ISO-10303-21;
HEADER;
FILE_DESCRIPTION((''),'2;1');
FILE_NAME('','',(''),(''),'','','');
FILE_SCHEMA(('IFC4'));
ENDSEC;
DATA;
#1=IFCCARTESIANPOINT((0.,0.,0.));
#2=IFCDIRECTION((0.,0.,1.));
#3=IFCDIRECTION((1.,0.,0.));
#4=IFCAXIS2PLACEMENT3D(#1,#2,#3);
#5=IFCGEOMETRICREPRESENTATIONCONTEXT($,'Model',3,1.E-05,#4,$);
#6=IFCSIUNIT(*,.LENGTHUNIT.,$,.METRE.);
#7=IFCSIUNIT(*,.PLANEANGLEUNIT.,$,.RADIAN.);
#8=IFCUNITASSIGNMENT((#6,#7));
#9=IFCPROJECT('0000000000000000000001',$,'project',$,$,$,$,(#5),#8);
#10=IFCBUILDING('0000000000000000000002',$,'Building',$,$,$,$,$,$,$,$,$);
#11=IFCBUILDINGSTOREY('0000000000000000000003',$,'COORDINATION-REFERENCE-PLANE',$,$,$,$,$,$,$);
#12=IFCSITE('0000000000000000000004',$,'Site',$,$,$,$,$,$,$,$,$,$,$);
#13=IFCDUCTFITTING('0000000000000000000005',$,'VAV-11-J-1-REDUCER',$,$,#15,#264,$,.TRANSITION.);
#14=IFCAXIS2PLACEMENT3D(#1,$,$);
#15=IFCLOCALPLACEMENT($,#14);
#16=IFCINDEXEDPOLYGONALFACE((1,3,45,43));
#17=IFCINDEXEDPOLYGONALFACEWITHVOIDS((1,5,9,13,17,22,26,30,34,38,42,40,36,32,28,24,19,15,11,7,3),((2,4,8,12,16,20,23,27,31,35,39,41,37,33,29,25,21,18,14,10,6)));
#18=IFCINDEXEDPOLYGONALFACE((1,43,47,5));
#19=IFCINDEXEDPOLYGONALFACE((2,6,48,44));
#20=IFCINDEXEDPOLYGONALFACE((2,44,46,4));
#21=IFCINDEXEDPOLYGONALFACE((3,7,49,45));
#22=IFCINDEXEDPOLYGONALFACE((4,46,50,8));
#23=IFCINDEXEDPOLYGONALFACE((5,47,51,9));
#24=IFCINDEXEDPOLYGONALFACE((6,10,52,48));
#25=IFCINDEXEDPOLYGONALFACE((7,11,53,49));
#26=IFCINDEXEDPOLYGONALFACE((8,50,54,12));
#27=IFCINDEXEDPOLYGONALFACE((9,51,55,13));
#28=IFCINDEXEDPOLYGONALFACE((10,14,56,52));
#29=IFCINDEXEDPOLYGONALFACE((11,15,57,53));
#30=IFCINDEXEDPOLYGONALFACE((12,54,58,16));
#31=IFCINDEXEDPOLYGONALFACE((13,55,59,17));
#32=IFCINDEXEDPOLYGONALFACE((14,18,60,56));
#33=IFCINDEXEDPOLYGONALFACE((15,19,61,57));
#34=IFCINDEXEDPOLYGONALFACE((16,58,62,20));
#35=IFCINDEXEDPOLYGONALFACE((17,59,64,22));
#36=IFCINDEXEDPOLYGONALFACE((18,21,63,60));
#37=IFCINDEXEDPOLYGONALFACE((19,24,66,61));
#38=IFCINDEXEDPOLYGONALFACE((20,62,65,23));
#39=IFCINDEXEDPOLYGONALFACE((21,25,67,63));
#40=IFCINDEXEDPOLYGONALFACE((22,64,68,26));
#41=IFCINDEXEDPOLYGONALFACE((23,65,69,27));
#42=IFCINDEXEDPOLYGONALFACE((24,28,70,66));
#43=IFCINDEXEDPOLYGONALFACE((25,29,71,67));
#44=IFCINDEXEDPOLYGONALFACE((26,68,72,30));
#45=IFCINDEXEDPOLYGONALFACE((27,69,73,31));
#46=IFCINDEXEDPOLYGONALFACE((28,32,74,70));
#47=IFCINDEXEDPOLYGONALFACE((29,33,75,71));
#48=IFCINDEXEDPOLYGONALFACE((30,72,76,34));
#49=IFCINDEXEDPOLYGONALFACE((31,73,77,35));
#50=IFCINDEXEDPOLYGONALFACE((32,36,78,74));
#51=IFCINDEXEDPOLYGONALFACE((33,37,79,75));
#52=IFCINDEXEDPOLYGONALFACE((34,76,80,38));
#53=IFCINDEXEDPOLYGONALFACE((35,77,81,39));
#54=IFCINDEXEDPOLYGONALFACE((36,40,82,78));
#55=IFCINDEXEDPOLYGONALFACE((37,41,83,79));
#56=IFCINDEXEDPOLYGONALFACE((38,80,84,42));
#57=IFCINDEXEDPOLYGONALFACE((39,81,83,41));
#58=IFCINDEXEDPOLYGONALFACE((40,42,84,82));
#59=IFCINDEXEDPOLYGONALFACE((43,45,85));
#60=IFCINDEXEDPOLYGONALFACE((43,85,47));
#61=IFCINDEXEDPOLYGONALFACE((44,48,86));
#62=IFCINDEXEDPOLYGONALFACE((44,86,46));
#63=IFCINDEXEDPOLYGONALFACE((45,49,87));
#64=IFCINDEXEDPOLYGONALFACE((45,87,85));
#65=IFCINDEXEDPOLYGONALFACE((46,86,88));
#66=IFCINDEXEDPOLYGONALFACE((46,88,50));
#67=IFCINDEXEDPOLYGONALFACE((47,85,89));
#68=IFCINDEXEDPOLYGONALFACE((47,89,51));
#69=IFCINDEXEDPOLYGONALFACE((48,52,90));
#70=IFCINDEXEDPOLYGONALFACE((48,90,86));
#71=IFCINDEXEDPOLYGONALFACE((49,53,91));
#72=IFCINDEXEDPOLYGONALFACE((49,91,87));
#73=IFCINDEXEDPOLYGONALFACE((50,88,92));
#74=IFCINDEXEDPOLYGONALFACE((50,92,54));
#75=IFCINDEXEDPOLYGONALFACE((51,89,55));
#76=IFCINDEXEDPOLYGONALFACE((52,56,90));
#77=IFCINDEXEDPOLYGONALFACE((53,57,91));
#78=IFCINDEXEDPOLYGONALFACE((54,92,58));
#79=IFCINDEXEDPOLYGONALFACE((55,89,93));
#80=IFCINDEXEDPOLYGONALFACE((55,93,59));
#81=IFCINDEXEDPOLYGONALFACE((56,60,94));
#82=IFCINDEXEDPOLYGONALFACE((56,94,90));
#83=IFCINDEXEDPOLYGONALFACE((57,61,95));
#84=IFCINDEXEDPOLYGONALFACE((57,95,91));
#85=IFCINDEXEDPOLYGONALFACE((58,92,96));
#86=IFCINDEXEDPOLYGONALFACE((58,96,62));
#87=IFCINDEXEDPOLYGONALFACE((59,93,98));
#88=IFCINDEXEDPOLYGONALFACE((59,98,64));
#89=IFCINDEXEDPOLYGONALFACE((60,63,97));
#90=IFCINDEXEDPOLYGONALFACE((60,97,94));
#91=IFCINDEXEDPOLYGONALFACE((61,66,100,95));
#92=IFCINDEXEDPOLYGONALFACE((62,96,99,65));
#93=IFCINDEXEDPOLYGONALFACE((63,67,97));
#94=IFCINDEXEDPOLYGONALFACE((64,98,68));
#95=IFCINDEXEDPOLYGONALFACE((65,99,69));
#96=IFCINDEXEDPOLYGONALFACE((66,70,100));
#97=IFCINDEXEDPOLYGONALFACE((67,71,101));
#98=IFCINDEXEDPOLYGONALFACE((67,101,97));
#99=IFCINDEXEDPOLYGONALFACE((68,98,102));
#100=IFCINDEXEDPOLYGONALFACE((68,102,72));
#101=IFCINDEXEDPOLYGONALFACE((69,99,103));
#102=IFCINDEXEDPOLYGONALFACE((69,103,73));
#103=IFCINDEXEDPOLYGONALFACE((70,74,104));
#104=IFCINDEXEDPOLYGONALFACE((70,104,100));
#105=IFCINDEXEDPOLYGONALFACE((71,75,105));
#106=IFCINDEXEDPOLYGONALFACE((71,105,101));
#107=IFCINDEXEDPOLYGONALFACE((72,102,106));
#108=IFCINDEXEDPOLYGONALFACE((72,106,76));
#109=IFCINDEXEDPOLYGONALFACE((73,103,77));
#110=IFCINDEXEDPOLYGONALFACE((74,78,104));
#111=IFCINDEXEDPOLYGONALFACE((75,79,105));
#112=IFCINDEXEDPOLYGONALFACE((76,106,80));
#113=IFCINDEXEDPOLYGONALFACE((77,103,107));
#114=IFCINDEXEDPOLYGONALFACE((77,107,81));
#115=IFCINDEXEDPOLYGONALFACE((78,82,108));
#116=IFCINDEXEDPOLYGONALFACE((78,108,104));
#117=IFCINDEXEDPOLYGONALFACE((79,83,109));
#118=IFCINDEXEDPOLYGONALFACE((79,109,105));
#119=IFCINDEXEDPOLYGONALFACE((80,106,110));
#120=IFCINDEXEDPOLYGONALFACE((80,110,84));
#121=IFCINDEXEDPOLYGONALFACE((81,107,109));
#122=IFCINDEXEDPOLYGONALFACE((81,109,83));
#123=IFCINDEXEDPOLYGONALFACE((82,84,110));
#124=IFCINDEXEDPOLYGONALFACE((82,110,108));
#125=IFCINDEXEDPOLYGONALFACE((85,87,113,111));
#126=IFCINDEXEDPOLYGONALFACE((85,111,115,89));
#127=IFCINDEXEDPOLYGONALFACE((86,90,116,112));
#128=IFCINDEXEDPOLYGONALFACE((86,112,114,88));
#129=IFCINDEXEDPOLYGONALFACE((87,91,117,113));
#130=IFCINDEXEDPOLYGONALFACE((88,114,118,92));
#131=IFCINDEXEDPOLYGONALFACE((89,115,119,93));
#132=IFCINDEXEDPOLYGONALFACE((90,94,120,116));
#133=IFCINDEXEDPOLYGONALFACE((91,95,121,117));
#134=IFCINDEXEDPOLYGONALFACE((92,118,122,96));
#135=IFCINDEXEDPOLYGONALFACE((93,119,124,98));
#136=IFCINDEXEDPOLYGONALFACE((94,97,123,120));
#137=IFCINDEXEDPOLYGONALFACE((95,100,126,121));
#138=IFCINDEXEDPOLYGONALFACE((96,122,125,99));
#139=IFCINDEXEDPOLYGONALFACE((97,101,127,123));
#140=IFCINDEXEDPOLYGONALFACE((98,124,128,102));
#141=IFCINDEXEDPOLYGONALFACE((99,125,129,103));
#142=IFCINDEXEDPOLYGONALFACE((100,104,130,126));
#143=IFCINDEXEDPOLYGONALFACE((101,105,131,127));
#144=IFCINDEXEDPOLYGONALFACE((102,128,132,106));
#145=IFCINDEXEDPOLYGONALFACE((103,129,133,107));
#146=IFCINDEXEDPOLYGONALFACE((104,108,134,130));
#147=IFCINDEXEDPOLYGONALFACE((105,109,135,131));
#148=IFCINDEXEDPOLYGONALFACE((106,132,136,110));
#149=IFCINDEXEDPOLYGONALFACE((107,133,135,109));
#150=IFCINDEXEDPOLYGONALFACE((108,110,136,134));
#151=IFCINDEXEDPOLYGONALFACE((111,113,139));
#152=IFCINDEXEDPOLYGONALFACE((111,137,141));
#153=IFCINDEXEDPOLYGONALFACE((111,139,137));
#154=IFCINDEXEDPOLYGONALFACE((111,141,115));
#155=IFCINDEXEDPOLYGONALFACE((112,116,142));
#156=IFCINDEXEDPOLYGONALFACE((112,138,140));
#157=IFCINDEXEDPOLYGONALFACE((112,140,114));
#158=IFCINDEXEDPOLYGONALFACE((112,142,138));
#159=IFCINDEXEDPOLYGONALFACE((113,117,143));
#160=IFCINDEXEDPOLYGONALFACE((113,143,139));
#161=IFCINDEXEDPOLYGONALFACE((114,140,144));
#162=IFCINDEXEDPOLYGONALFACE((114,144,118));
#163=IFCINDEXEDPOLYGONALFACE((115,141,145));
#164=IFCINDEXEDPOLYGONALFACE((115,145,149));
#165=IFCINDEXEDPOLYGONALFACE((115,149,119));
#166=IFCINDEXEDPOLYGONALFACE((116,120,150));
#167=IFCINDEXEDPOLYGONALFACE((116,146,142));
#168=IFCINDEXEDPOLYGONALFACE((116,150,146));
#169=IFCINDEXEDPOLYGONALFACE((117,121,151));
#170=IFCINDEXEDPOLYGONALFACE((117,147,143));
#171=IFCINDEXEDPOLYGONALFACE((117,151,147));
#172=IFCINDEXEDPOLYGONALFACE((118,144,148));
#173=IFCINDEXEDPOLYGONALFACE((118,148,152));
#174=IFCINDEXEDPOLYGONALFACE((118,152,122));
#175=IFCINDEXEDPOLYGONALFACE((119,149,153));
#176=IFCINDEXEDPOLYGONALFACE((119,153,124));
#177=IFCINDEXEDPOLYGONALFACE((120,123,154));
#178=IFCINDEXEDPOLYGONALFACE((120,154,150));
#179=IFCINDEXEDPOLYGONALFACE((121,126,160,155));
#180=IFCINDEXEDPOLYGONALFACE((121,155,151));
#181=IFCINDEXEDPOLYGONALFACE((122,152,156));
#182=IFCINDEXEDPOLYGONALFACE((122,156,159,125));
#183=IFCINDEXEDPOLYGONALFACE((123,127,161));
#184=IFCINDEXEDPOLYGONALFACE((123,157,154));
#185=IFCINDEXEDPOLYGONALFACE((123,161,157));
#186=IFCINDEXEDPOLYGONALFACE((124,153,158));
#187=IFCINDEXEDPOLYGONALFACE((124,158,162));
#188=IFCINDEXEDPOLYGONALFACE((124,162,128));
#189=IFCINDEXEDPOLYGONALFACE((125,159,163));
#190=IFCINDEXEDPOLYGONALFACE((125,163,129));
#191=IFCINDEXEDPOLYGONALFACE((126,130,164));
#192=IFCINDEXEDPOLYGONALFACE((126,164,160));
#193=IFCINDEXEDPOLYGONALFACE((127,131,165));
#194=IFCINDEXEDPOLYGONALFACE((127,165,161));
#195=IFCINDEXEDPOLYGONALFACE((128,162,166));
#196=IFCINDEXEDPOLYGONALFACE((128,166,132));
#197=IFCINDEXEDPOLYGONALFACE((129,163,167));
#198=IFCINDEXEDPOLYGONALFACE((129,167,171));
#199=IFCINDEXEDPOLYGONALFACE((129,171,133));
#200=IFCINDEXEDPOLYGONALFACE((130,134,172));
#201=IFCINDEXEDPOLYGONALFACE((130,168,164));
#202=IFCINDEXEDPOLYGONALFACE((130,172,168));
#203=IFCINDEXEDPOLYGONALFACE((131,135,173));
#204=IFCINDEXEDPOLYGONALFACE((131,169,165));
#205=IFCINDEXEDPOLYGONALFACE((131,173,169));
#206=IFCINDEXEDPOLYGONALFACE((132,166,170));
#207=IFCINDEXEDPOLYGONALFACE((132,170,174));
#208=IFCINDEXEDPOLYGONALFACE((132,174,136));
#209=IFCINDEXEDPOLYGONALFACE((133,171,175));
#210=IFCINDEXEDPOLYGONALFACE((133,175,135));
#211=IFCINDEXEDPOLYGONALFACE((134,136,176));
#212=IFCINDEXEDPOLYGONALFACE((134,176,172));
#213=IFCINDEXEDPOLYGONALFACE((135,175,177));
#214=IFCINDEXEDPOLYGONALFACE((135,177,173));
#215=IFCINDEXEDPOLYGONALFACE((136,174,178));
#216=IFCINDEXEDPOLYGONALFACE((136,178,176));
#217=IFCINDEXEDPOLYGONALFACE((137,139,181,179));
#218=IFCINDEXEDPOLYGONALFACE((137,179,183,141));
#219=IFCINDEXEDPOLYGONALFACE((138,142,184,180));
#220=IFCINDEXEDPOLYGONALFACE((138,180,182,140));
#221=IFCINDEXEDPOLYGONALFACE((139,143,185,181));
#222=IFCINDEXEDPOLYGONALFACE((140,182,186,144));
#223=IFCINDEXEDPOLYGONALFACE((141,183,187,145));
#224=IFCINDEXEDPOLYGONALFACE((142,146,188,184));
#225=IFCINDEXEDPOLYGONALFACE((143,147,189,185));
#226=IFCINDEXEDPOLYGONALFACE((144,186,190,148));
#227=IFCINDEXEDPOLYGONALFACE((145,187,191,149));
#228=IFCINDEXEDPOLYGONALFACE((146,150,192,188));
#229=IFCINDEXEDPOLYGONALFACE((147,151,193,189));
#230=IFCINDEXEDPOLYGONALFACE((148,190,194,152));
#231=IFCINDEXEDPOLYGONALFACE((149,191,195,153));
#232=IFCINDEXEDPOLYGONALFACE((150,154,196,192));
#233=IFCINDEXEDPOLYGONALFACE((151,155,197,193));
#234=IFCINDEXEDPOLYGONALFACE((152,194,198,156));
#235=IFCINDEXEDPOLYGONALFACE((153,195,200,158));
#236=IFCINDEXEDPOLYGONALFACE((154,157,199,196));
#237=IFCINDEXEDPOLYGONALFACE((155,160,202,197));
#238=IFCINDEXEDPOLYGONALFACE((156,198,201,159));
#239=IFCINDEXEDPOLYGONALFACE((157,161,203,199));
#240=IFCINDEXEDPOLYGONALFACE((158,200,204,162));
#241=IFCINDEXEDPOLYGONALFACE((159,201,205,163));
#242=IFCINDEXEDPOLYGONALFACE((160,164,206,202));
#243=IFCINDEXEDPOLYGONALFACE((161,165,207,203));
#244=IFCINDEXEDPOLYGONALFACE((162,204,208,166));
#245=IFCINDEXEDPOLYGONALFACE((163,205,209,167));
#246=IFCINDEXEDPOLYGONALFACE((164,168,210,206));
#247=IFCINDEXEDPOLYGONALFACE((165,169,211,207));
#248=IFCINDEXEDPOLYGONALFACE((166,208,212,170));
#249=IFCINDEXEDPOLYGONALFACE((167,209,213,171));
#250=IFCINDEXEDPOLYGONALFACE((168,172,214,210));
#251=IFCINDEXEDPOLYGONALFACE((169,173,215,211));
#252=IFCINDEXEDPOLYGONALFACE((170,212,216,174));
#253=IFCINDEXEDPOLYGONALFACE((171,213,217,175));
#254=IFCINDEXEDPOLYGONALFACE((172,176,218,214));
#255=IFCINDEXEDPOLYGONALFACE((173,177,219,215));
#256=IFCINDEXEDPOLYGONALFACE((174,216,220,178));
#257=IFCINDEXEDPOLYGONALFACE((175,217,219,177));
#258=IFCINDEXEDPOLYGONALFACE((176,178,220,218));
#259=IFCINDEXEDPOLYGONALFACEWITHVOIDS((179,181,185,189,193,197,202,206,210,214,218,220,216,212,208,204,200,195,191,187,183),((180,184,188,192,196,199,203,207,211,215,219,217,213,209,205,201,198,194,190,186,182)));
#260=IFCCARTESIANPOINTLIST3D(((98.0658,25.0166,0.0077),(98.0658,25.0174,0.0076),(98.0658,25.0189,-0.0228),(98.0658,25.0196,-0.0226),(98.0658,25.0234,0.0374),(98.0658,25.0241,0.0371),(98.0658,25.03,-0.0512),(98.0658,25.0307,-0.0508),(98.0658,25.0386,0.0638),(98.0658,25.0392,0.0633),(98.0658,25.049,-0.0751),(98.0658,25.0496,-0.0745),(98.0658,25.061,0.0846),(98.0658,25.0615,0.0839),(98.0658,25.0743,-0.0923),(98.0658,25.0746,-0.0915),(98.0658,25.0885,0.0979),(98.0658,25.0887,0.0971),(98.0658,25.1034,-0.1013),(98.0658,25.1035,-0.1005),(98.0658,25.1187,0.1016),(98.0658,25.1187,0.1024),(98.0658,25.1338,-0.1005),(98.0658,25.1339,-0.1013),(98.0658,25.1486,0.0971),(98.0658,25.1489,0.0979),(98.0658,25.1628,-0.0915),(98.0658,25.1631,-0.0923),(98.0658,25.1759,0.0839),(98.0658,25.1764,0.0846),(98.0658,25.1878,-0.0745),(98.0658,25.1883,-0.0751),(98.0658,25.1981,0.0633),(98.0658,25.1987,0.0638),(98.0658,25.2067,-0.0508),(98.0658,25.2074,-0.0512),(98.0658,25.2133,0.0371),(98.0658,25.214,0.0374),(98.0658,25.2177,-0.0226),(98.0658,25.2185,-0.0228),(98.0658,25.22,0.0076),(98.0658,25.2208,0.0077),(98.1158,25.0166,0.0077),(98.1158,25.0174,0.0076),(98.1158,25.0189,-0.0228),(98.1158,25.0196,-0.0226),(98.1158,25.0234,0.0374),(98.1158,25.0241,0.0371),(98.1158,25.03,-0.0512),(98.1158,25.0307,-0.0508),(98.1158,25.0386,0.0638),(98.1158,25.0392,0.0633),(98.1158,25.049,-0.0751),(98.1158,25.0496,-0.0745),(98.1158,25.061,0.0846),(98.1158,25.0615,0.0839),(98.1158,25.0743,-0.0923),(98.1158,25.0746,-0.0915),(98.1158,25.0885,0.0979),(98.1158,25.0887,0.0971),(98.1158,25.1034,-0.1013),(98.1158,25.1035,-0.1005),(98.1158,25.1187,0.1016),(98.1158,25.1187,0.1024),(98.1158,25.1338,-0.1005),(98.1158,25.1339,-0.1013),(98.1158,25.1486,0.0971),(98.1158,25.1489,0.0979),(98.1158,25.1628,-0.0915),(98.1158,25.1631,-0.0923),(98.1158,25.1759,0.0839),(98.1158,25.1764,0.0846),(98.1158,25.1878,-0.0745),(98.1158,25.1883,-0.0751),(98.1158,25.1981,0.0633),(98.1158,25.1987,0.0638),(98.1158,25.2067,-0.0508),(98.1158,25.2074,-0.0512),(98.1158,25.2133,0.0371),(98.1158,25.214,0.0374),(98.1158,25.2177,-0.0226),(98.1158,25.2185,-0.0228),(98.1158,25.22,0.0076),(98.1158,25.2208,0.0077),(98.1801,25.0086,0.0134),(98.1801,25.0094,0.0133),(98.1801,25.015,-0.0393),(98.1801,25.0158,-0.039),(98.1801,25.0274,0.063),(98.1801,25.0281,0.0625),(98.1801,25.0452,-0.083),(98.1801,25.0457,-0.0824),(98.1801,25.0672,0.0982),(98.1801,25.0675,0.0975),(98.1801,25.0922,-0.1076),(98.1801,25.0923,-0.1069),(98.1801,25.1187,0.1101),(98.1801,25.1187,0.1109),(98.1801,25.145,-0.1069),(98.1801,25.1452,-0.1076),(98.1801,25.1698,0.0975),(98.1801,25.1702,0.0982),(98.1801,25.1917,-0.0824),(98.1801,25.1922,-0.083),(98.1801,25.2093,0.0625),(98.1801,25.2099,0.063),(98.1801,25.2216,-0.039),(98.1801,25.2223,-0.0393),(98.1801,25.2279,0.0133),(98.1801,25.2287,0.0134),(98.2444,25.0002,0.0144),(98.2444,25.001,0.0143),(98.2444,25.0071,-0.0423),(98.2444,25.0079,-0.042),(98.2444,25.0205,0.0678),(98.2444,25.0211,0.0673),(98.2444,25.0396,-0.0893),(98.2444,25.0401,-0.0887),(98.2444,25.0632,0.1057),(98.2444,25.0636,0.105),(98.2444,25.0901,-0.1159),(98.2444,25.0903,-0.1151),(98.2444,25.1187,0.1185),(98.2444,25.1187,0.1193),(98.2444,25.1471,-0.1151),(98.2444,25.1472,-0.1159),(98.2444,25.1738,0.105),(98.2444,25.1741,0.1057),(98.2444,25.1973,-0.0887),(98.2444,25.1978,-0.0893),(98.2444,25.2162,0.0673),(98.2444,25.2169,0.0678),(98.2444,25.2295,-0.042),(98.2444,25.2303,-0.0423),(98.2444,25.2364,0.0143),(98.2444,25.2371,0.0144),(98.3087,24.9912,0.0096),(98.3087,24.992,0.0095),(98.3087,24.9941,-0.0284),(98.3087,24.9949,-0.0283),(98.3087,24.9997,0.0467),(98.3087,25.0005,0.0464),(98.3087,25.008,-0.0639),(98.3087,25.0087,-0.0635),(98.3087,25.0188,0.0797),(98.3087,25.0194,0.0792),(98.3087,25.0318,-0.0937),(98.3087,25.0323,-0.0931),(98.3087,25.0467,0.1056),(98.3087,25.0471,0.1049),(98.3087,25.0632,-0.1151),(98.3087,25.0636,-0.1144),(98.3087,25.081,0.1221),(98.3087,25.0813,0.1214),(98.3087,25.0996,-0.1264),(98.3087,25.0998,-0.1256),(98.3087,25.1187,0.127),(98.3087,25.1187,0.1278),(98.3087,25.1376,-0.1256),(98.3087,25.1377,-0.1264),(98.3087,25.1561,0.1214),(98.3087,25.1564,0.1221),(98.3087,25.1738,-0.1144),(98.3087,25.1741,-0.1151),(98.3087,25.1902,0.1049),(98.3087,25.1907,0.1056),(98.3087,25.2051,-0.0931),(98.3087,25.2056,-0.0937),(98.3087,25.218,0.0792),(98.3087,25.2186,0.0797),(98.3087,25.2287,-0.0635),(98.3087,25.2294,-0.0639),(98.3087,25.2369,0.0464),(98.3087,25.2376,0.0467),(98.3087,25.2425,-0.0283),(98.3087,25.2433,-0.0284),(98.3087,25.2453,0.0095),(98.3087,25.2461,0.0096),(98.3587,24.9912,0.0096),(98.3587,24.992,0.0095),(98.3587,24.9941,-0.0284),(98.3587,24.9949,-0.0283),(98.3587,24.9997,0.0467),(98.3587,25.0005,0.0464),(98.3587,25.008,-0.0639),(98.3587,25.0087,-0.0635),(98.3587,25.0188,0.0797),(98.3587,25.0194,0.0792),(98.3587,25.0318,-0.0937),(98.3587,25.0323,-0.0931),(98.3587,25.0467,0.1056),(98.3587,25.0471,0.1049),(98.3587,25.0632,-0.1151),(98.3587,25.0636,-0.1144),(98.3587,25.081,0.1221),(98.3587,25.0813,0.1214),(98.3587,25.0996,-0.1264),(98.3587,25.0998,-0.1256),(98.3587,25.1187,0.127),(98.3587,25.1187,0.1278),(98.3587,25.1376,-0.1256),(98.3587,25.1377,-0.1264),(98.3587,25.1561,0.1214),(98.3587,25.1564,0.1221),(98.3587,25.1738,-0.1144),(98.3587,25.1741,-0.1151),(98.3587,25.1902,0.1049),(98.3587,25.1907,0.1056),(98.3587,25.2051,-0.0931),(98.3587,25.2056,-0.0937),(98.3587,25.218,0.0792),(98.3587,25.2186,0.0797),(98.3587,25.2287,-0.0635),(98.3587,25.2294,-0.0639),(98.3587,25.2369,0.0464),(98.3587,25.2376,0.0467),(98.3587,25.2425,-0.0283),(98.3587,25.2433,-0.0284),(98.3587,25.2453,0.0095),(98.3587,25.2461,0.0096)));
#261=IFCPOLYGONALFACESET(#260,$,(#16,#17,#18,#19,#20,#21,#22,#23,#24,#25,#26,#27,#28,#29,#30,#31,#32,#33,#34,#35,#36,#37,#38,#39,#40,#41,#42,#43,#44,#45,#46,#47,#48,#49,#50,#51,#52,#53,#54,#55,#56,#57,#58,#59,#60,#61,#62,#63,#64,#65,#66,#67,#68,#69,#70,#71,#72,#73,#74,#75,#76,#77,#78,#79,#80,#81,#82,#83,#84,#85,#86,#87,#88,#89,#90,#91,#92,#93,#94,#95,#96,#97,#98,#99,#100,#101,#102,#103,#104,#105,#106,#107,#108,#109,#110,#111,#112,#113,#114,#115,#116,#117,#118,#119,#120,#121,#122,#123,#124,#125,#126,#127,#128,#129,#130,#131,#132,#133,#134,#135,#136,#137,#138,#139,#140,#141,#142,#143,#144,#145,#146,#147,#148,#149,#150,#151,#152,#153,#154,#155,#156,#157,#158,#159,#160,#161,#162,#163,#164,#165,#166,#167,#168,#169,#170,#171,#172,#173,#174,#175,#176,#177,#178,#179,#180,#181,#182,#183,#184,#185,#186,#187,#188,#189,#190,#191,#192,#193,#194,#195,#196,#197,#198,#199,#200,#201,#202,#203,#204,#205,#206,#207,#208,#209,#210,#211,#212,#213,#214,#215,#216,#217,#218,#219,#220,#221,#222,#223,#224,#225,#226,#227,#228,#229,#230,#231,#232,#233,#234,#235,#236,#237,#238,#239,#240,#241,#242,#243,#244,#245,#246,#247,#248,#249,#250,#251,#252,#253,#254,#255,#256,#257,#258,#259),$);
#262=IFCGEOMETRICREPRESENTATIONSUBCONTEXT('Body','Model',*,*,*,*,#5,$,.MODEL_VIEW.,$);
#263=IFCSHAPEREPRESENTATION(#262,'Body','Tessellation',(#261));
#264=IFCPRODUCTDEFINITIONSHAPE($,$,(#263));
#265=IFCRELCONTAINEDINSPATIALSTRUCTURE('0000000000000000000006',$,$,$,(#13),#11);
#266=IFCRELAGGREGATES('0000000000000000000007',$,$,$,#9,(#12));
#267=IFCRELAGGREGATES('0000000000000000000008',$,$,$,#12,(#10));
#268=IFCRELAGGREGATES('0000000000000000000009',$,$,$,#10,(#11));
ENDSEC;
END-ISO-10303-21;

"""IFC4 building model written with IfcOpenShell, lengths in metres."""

from ifc_helpers import new_model, entity, si_unit, frame, origin_with_axes, place, context, subcontext, project, spatial, element, save


model = new_model("IFC4")

# Units and contexts
model_context = context("Model", 3, precision=1e-05, world=origin_with_axes())
body_context_1 = subcontext(model_context, "Body", "Model", "MODEL_VIEW")
ifc_project = project(units=[si_unit("LENGTHUNIT", "METRE"), si_unit("PLANEANGLEUNIT", "RADIAN")], contexts=[model_context])

# Site, building, storey
site = spatial("IfcSite", under=ifc_project, Name="Site")
building = spatial("IfcBuilding", under=site, Name="Building")
storey = spatial("IfcBuildingStorey", under=building, Name="COORDINATION-REFERENCE-PLANE")

# Duct fitting
for number, where, z_axis, x_axis, name in (
    (1, (98.3587, 25.1187, 0.0), (0.0, -1.0, 0.0), (0.0, 0.0, 1.0), "VAV-11-J-1-REDUCER"),
):
    element("IfcDuctFitting", number, at=place(None, frame(where, z_axis=z_axis, x_axis=x_axis)), inside=storey, Name=name, PredefinedType="TRANSITION", context=body_context_1, shape_type="SweptSolid", body=[
        entity("IfcRevolvedAreaSolid", entity("IfcArbitraryClosedProfileDef", "AREA", None, entity("IfcPolyline", [entity("IfcCartesianPoint", [0.1278, 0.0]), entity("IfcCartesianPoint", [0.1278, 0.05]), entity("IfcCartesianPoint", [0.1024, 0.2429]), entity("IfcCartesianPoint", [0.1024, 0.2929]), entity("IfcCartesianPoint", [0.1016, 0.2929]), entity("IfcCartesianPoint", [0.1016, 0.2429]), entity("IfcCartesianPoint", [0.127, 0.05]), entity("IfcCartesianPoint", [0.127, 0.0]), entity("IfcCartesianPoint", [0.1278, 0.0])])), entity("IfcAxis2Placement3D", entity("IfcCartesianPoint", [0.0, 0.0, 0.0])), entity("IfcAxis1Placement", entity("IfcCartesianPoint", [0.0, 0.0, 0.0]), entity("IfcDirection", [0.0, 1.0, 0.0])), 6.283185),
    ])

save(model, "model.ifc")
